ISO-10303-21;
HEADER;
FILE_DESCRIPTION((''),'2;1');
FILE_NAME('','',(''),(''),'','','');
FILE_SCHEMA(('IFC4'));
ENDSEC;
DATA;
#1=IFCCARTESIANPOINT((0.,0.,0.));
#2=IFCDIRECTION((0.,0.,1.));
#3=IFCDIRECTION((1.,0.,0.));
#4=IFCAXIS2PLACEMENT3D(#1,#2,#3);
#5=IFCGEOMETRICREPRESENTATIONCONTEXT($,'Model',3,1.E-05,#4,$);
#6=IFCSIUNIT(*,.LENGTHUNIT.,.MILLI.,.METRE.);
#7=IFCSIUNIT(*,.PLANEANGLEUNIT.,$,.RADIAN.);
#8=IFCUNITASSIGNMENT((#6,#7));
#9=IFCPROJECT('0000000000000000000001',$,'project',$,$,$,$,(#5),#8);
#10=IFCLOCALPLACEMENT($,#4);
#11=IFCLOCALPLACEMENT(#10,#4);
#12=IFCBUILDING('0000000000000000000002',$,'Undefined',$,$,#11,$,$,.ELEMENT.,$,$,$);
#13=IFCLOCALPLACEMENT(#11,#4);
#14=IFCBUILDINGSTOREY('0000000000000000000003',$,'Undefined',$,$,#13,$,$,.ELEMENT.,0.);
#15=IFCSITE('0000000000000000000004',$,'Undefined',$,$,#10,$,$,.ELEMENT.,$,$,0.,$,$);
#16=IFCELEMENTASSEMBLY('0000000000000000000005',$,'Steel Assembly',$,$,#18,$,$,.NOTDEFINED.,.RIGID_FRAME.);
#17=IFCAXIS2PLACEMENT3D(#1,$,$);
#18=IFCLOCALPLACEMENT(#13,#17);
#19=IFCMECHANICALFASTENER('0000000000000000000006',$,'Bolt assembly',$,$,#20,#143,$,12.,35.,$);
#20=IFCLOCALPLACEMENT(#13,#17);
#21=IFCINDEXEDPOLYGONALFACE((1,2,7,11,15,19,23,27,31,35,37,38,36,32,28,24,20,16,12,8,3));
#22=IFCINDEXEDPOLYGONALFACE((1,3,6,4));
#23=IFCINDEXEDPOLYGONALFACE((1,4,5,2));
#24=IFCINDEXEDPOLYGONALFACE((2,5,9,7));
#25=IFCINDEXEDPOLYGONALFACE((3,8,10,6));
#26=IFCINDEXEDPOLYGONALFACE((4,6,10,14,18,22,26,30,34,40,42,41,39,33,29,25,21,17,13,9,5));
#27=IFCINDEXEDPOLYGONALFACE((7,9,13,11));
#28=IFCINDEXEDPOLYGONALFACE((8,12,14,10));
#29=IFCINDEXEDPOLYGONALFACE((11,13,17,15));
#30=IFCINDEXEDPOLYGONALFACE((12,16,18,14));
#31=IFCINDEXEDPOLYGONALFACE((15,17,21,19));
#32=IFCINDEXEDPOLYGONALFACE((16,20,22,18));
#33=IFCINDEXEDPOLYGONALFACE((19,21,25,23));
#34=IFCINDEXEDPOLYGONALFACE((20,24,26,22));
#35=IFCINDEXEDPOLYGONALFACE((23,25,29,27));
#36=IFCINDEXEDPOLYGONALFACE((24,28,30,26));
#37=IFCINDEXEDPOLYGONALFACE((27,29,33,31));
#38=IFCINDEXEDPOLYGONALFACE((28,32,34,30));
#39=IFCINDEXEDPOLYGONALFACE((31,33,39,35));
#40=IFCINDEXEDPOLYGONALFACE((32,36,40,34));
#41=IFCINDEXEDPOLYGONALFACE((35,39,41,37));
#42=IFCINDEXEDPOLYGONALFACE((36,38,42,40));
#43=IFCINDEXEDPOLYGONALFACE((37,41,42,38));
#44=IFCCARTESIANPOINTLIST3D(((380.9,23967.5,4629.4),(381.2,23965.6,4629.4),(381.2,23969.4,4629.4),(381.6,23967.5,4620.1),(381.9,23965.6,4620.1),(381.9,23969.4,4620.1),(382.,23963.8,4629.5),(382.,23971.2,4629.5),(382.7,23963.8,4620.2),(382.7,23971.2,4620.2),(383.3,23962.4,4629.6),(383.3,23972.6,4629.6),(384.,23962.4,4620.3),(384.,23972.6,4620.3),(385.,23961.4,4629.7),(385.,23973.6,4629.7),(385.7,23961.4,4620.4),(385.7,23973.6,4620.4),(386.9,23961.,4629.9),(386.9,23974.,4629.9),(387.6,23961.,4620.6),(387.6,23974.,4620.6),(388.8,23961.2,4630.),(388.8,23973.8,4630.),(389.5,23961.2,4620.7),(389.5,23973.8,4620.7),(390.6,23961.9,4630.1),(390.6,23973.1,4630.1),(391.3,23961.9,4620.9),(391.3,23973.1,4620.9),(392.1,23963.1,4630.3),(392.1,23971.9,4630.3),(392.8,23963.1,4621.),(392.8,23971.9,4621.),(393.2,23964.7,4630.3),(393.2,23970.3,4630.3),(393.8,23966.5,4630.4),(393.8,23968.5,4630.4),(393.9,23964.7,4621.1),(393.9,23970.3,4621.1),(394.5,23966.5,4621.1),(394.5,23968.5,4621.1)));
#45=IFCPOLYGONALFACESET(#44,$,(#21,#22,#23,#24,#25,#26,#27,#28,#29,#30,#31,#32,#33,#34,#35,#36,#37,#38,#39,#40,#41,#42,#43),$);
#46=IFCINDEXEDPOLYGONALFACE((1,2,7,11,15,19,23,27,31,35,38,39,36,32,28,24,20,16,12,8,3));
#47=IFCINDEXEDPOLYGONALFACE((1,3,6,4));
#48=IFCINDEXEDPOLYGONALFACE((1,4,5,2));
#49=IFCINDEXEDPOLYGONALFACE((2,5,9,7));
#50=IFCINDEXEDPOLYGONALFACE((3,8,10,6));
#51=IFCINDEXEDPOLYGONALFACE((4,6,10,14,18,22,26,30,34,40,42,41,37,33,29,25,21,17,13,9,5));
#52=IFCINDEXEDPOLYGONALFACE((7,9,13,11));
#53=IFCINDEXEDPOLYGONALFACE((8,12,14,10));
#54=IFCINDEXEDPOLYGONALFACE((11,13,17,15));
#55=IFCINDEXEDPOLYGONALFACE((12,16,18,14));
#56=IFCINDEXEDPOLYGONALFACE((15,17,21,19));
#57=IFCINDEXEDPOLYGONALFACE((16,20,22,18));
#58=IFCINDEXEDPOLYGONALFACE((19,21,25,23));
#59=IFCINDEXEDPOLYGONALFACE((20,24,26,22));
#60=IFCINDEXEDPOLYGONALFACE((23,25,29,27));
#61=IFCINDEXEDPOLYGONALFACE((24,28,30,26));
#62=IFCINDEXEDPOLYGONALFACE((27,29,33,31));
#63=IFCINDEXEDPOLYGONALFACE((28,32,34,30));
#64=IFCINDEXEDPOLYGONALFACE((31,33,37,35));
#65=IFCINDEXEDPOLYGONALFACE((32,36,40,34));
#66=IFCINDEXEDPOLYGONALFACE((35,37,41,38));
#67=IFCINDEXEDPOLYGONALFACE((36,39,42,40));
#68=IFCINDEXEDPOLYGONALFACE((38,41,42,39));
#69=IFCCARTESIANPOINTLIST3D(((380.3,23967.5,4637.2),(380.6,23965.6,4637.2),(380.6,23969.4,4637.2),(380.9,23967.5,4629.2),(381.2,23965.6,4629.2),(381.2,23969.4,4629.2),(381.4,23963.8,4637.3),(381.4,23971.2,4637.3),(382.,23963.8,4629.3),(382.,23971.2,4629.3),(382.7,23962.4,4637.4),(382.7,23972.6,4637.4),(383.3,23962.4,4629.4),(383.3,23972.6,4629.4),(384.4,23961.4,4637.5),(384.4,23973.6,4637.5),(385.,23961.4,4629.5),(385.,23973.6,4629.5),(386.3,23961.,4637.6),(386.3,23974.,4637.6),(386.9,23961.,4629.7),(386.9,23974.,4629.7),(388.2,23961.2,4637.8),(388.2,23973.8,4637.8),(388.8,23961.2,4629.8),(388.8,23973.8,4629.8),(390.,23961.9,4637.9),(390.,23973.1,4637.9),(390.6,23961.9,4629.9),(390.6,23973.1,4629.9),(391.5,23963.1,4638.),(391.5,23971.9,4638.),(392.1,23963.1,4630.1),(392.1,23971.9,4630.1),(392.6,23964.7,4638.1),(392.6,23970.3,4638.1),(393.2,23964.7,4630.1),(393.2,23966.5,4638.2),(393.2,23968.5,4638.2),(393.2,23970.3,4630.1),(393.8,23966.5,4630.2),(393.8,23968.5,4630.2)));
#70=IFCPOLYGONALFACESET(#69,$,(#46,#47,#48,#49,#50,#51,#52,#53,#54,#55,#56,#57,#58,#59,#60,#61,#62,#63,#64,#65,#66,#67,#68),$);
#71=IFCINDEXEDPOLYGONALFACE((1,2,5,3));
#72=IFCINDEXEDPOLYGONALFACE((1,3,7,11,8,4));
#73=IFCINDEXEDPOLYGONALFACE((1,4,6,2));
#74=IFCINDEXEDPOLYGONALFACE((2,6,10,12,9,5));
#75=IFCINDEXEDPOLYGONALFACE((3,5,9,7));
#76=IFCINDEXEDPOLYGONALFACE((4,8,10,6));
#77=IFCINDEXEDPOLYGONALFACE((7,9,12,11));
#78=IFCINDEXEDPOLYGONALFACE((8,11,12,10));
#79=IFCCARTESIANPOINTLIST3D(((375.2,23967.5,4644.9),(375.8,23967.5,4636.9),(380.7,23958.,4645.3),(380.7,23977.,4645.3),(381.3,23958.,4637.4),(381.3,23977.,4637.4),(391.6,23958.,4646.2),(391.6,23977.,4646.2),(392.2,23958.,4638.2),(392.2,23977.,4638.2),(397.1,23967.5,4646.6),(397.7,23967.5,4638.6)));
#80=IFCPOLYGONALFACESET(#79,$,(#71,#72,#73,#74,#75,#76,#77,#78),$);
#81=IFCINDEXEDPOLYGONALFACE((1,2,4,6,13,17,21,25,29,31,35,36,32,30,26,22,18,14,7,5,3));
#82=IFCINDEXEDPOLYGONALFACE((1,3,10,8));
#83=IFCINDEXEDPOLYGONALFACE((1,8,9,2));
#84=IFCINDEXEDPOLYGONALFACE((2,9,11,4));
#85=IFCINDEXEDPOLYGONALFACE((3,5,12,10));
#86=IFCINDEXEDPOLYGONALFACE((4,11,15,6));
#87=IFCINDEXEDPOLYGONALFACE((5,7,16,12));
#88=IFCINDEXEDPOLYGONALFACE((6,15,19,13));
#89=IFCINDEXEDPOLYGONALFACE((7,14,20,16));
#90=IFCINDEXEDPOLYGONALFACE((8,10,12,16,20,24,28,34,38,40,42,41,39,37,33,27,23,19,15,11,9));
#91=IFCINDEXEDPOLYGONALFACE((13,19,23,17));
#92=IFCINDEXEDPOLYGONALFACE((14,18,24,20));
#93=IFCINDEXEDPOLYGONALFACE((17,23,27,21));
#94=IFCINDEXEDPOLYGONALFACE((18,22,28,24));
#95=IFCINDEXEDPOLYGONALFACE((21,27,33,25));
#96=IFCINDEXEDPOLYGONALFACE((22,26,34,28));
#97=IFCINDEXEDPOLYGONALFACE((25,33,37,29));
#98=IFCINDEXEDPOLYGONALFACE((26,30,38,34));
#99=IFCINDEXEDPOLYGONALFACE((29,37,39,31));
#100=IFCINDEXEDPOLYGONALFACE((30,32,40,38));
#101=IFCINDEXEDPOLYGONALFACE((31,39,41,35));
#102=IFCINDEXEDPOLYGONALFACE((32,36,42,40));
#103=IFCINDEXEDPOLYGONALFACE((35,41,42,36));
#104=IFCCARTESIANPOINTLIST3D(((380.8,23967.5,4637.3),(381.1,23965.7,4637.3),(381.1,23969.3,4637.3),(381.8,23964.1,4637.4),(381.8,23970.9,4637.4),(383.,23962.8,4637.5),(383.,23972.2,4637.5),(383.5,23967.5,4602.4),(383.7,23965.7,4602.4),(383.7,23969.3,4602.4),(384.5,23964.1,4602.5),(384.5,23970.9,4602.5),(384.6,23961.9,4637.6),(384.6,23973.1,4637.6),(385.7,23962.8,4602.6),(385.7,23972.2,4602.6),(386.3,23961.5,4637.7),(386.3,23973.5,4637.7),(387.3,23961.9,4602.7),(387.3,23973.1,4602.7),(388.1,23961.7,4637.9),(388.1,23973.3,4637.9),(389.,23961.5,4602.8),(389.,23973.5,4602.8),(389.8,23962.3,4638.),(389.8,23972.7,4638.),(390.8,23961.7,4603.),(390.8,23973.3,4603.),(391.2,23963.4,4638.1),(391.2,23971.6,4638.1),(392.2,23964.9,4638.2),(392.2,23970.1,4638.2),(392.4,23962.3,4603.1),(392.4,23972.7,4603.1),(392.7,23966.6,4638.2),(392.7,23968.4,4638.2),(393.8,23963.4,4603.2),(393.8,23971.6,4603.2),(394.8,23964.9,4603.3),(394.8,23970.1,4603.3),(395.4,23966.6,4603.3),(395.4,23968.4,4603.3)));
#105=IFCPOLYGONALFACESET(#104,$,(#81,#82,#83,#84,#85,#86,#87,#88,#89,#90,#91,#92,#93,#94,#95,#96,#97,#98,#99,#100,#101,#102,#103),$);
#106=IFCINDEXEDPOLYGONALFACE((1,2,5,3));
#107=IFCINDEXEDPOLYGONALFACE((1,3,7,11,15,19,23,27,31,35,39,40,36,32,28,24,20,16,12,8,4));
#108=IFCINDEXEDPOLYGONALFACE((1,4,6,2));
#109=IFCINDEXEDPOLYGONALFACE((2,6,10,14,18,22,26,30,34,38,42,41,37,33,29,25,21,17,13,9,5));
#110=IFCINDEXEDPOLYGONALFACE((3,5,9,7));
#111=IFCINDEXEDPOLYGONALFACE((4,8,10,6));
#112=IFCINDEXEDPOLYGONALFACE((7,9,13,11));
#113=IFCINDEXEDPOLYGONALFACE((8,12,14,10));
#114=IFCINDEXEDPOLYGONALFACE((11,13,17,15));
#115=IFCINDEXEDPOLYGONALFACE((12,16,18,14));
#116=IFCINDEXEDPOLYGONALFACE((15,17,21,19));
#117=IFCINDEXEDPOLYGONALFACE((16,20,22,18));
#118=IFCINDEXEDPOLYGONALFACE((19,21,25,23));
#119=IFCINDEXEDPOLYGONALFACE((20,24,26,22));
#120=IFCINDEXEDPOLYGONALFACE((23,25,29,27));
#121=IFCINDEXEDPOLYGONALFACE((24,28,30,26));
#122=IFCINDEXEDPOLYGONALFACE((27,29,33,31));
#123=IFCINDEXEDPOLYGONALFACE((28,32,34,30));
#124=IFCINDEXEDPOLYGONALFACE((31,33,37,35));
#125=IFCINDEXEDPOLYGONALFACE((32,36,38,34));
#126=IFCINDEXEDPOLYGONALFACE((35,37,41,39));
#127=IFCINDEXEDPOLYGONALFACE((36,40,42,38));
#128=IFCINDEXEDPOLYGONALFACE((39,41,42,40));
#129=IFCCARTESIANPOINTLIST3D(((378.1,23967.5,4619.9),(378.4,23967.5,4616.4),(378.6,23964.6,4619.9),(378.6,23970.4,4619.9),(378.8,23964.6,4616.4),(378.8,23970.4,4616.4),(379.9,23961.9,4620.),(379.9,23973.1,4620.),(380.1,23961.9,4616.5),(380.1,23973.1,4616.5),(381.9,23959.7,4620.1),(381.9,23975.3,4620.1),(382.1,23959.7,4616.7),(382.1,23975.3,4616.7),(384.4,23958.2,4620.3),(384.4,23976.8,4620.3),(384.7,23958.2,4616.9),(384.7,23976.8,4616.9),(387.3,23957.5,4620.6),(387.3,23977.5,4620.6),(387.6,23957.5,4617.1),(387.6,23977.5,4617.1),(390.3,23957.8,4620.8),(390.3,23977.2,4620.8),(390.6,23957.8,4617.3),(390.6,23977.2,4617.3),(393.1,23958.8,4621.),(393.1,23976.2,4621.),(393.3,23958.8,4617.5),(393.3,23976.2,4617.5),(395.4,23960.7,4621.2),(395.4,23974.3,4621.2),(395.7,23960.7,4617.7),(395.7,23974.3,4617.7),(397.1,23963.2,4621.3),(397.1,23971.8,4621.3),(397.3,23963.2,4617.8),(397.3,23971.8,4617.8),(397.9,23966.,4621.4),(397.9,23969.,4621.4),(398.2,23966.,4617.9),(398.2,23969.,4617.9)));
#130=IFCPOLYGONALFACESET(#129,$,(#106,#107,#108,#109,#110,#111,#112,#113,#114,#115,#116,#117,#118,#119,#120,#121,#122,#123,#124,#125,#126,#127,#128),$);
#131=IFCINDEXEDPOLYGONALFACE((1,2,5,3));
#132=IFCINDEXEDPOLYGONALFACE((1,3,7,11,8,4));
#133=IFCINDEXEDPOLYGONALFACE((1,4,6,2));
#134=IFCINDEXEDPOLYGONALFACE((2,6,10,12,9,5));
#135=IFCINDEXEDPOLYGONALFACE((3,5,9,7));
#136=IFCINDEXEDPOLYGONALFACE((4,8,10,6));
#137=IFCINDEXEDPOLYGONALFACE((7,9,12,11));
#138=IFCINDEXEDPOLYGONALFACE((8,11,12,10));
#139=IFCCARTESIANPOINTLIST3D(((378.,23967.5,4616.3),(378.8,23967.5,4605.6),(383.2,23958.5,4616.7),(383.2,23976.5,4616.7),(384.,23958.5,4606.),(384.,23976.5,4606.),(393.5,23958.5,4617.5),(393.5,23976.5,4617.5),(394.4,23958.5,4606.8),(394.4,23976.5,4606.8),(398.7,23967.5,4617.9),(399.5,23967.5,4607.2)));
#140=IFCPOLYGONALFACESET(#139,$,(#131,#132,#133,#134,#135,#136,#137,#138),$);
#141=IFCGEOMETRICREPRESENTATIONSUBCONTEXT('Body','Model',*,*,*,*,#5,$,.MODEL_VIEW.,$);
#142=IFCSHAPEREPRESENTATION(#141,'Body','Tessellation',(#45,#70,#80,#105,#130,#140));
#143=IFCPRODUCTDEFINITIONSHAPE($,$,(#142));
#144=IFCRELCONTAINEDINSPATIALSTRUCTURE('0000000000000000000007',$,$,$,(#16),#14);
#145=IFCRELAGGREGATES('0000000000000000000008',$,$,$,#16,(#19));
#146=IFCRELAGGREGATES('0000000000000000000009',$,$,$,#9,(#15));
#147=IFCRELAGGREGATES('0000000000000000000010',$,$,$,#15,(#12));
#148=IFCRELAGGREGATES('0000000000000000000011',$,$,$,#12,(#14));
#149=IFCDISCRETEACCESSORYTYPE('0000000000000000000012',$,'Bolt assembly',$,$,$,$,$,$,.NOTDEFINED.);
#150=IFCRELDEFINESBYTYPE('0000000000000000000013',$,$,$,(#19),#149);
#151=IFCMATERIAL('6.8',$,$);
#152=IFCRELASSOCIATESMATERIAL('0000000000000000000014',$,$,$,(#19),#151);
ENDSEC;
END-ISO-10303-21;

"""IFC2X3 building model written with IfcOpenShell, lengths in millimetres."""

from ifc_helpers import new_model, si_unit, frame, origin_with_axes, origin_2d_with_axis, place, context, subcontext, project, spatial, polyline, circle, outline, extrude, source, transform, mapped, material, type_object, element, aggregate, save


model = new_model("IFC2X3")

# Units and contexts
model_context = context("Model", 3, precision=1e-05, world=origin_with_axes())
body_context = subcontext(model_context, "Body", "Model", "MODEL_VIEW")
ifc_project = project(units=[si_unit("LENGTHUNIT", "METRE", prefix="MILLI"), si_unit("PLANEANGLEUNIT", "RADIAN")], contexts=[model_context])

# Site, building, storey
site_placement = place(None, origin_with_axes())
site = spatial("IfcSite", under=ifc_project, at=site_placement, Name="Undefined", CompositionType="ELEMENT", RefElevation=0.0)
building_placement = place(site_placement, origin_with_axes())
building = spatial("IfcBuilding", under=site, at=building_placement, Name="Undefined", CompositionType="ELEMENT")
storey_placement = place(building_placement, origin_with_axes())
storey = spatial("IfcBuildingStorey", under=building, at=storey_placement, Name="Undefined", CompositionType="ELEMENT", Elevation=0.0)

# Shared definitions
ifc_material_1 = material(Name="6.8")
discrete_accessory_type_1 = type_object("IfcDiscreteAccessoryType", Name="Bolt assembly")

# Element assembly, mechanical fastener
shared_shape_1 = source(origin_with_axes(), body_context, "Body", "SweptSolid", [
    extrude(circle(Radius=6.5, at=origin_2d_with_axis()), frame((0.0, -0.1, 0.0), z_axis=(0.0, 1.0, 0.0), x_axis=(1.0, 0.0, 0.0)), (0.0, 0.0, 1.0), 9.3),
    extrude(circle(Radius=6.5, at=origin_2d_with_axis()), frame((0.0, -7.9, 0.0), z_axis=(0.0, 1.0, 0.0), x_axis=(1.0, 0.0, 0.0)), (0.0, 0.0, 1.0), 8.0),
    extrude(outline(polyline([(11.0, 0.0), (5.5, 9.5), (-5.5, 9.5), (-11.0, 0.0), (-5.5, -9.5), (5.5, -9.5), (11.0, 0.0)])), frame((0.0, -16.0, 0.0), z_axis=(0.0, 1.0, 0.0), x_axis=(1.0, 0.0, 0.0)), (0.0, 0.0, 1.0), 8.0),
    extrude(circle(Radius=6.0, at=origin_2d_with_axis()), frame((0.0, -8.0, 0.0), z_axis=(0.0, 1.0, 0.0), x_axis=(1.0, 0.0, 0.0)), (0.0, 0.0, 1.0), 35.0),
    extrude(circle(Radius=10.0, at=origin_2d_with_axis()), frame((0.0, 9.2, 0.0), z_axis=(0.0, 1.0, 0.0), x_axis=(1.0, 0.0, 0.0)), (0.0, 0.0, 1.0), 3.5),
    extrude(outline(polyline([(10.4, 0.0), (5.2, 9.0), (-5.2, 9.0), (-10.4, 0.0), (-5.2, -9.0), (5.2, -9.0), (10.4, 0.0)])), frame((0.0, 12.7, 0.0), z_axis=(0.0, 1.0, 0.0), x_axis=(1.0, 0.0, 0.0)), (0.0, 0.0, 1.0), 10.8),
])
assembly_1_placement = place(storey_placement, origin_with_axes())
assembly_1 = element("IfcElementAssembly", 1, at=assembly_1_placement, inside=storey, Name="Steel Assembly", AssemblyPlace="NOTDEFINED", PredefinedType="RIGID_FRAME")
mechanical_fastener_1_placement = place(assembly_1_placement, frame((387.4, 23967.5, 4629.8), z_axis=(0.0, -1.0, 0.0), x_axis=(-0.997054, 0.0, -0.076696)))
mechanical_fastener_1 = element("IfcMechanicalFastener", 2, at=mechanical_fastener_1_placement, type_object=discrete_accessory_type_1, material=ifc_material_1, Name="Bolt assembly", NominalDiameter=12.0, NominalLength=35.0, context=body_context, shape_type="MappedRepresentation", body=[
    mapped(shared_shape_1, transform((0.0, 0.0, 0.0))),
])
aggregate(assembly_1, [mechanical_fastener_1])

save(model, "model.ifc")
